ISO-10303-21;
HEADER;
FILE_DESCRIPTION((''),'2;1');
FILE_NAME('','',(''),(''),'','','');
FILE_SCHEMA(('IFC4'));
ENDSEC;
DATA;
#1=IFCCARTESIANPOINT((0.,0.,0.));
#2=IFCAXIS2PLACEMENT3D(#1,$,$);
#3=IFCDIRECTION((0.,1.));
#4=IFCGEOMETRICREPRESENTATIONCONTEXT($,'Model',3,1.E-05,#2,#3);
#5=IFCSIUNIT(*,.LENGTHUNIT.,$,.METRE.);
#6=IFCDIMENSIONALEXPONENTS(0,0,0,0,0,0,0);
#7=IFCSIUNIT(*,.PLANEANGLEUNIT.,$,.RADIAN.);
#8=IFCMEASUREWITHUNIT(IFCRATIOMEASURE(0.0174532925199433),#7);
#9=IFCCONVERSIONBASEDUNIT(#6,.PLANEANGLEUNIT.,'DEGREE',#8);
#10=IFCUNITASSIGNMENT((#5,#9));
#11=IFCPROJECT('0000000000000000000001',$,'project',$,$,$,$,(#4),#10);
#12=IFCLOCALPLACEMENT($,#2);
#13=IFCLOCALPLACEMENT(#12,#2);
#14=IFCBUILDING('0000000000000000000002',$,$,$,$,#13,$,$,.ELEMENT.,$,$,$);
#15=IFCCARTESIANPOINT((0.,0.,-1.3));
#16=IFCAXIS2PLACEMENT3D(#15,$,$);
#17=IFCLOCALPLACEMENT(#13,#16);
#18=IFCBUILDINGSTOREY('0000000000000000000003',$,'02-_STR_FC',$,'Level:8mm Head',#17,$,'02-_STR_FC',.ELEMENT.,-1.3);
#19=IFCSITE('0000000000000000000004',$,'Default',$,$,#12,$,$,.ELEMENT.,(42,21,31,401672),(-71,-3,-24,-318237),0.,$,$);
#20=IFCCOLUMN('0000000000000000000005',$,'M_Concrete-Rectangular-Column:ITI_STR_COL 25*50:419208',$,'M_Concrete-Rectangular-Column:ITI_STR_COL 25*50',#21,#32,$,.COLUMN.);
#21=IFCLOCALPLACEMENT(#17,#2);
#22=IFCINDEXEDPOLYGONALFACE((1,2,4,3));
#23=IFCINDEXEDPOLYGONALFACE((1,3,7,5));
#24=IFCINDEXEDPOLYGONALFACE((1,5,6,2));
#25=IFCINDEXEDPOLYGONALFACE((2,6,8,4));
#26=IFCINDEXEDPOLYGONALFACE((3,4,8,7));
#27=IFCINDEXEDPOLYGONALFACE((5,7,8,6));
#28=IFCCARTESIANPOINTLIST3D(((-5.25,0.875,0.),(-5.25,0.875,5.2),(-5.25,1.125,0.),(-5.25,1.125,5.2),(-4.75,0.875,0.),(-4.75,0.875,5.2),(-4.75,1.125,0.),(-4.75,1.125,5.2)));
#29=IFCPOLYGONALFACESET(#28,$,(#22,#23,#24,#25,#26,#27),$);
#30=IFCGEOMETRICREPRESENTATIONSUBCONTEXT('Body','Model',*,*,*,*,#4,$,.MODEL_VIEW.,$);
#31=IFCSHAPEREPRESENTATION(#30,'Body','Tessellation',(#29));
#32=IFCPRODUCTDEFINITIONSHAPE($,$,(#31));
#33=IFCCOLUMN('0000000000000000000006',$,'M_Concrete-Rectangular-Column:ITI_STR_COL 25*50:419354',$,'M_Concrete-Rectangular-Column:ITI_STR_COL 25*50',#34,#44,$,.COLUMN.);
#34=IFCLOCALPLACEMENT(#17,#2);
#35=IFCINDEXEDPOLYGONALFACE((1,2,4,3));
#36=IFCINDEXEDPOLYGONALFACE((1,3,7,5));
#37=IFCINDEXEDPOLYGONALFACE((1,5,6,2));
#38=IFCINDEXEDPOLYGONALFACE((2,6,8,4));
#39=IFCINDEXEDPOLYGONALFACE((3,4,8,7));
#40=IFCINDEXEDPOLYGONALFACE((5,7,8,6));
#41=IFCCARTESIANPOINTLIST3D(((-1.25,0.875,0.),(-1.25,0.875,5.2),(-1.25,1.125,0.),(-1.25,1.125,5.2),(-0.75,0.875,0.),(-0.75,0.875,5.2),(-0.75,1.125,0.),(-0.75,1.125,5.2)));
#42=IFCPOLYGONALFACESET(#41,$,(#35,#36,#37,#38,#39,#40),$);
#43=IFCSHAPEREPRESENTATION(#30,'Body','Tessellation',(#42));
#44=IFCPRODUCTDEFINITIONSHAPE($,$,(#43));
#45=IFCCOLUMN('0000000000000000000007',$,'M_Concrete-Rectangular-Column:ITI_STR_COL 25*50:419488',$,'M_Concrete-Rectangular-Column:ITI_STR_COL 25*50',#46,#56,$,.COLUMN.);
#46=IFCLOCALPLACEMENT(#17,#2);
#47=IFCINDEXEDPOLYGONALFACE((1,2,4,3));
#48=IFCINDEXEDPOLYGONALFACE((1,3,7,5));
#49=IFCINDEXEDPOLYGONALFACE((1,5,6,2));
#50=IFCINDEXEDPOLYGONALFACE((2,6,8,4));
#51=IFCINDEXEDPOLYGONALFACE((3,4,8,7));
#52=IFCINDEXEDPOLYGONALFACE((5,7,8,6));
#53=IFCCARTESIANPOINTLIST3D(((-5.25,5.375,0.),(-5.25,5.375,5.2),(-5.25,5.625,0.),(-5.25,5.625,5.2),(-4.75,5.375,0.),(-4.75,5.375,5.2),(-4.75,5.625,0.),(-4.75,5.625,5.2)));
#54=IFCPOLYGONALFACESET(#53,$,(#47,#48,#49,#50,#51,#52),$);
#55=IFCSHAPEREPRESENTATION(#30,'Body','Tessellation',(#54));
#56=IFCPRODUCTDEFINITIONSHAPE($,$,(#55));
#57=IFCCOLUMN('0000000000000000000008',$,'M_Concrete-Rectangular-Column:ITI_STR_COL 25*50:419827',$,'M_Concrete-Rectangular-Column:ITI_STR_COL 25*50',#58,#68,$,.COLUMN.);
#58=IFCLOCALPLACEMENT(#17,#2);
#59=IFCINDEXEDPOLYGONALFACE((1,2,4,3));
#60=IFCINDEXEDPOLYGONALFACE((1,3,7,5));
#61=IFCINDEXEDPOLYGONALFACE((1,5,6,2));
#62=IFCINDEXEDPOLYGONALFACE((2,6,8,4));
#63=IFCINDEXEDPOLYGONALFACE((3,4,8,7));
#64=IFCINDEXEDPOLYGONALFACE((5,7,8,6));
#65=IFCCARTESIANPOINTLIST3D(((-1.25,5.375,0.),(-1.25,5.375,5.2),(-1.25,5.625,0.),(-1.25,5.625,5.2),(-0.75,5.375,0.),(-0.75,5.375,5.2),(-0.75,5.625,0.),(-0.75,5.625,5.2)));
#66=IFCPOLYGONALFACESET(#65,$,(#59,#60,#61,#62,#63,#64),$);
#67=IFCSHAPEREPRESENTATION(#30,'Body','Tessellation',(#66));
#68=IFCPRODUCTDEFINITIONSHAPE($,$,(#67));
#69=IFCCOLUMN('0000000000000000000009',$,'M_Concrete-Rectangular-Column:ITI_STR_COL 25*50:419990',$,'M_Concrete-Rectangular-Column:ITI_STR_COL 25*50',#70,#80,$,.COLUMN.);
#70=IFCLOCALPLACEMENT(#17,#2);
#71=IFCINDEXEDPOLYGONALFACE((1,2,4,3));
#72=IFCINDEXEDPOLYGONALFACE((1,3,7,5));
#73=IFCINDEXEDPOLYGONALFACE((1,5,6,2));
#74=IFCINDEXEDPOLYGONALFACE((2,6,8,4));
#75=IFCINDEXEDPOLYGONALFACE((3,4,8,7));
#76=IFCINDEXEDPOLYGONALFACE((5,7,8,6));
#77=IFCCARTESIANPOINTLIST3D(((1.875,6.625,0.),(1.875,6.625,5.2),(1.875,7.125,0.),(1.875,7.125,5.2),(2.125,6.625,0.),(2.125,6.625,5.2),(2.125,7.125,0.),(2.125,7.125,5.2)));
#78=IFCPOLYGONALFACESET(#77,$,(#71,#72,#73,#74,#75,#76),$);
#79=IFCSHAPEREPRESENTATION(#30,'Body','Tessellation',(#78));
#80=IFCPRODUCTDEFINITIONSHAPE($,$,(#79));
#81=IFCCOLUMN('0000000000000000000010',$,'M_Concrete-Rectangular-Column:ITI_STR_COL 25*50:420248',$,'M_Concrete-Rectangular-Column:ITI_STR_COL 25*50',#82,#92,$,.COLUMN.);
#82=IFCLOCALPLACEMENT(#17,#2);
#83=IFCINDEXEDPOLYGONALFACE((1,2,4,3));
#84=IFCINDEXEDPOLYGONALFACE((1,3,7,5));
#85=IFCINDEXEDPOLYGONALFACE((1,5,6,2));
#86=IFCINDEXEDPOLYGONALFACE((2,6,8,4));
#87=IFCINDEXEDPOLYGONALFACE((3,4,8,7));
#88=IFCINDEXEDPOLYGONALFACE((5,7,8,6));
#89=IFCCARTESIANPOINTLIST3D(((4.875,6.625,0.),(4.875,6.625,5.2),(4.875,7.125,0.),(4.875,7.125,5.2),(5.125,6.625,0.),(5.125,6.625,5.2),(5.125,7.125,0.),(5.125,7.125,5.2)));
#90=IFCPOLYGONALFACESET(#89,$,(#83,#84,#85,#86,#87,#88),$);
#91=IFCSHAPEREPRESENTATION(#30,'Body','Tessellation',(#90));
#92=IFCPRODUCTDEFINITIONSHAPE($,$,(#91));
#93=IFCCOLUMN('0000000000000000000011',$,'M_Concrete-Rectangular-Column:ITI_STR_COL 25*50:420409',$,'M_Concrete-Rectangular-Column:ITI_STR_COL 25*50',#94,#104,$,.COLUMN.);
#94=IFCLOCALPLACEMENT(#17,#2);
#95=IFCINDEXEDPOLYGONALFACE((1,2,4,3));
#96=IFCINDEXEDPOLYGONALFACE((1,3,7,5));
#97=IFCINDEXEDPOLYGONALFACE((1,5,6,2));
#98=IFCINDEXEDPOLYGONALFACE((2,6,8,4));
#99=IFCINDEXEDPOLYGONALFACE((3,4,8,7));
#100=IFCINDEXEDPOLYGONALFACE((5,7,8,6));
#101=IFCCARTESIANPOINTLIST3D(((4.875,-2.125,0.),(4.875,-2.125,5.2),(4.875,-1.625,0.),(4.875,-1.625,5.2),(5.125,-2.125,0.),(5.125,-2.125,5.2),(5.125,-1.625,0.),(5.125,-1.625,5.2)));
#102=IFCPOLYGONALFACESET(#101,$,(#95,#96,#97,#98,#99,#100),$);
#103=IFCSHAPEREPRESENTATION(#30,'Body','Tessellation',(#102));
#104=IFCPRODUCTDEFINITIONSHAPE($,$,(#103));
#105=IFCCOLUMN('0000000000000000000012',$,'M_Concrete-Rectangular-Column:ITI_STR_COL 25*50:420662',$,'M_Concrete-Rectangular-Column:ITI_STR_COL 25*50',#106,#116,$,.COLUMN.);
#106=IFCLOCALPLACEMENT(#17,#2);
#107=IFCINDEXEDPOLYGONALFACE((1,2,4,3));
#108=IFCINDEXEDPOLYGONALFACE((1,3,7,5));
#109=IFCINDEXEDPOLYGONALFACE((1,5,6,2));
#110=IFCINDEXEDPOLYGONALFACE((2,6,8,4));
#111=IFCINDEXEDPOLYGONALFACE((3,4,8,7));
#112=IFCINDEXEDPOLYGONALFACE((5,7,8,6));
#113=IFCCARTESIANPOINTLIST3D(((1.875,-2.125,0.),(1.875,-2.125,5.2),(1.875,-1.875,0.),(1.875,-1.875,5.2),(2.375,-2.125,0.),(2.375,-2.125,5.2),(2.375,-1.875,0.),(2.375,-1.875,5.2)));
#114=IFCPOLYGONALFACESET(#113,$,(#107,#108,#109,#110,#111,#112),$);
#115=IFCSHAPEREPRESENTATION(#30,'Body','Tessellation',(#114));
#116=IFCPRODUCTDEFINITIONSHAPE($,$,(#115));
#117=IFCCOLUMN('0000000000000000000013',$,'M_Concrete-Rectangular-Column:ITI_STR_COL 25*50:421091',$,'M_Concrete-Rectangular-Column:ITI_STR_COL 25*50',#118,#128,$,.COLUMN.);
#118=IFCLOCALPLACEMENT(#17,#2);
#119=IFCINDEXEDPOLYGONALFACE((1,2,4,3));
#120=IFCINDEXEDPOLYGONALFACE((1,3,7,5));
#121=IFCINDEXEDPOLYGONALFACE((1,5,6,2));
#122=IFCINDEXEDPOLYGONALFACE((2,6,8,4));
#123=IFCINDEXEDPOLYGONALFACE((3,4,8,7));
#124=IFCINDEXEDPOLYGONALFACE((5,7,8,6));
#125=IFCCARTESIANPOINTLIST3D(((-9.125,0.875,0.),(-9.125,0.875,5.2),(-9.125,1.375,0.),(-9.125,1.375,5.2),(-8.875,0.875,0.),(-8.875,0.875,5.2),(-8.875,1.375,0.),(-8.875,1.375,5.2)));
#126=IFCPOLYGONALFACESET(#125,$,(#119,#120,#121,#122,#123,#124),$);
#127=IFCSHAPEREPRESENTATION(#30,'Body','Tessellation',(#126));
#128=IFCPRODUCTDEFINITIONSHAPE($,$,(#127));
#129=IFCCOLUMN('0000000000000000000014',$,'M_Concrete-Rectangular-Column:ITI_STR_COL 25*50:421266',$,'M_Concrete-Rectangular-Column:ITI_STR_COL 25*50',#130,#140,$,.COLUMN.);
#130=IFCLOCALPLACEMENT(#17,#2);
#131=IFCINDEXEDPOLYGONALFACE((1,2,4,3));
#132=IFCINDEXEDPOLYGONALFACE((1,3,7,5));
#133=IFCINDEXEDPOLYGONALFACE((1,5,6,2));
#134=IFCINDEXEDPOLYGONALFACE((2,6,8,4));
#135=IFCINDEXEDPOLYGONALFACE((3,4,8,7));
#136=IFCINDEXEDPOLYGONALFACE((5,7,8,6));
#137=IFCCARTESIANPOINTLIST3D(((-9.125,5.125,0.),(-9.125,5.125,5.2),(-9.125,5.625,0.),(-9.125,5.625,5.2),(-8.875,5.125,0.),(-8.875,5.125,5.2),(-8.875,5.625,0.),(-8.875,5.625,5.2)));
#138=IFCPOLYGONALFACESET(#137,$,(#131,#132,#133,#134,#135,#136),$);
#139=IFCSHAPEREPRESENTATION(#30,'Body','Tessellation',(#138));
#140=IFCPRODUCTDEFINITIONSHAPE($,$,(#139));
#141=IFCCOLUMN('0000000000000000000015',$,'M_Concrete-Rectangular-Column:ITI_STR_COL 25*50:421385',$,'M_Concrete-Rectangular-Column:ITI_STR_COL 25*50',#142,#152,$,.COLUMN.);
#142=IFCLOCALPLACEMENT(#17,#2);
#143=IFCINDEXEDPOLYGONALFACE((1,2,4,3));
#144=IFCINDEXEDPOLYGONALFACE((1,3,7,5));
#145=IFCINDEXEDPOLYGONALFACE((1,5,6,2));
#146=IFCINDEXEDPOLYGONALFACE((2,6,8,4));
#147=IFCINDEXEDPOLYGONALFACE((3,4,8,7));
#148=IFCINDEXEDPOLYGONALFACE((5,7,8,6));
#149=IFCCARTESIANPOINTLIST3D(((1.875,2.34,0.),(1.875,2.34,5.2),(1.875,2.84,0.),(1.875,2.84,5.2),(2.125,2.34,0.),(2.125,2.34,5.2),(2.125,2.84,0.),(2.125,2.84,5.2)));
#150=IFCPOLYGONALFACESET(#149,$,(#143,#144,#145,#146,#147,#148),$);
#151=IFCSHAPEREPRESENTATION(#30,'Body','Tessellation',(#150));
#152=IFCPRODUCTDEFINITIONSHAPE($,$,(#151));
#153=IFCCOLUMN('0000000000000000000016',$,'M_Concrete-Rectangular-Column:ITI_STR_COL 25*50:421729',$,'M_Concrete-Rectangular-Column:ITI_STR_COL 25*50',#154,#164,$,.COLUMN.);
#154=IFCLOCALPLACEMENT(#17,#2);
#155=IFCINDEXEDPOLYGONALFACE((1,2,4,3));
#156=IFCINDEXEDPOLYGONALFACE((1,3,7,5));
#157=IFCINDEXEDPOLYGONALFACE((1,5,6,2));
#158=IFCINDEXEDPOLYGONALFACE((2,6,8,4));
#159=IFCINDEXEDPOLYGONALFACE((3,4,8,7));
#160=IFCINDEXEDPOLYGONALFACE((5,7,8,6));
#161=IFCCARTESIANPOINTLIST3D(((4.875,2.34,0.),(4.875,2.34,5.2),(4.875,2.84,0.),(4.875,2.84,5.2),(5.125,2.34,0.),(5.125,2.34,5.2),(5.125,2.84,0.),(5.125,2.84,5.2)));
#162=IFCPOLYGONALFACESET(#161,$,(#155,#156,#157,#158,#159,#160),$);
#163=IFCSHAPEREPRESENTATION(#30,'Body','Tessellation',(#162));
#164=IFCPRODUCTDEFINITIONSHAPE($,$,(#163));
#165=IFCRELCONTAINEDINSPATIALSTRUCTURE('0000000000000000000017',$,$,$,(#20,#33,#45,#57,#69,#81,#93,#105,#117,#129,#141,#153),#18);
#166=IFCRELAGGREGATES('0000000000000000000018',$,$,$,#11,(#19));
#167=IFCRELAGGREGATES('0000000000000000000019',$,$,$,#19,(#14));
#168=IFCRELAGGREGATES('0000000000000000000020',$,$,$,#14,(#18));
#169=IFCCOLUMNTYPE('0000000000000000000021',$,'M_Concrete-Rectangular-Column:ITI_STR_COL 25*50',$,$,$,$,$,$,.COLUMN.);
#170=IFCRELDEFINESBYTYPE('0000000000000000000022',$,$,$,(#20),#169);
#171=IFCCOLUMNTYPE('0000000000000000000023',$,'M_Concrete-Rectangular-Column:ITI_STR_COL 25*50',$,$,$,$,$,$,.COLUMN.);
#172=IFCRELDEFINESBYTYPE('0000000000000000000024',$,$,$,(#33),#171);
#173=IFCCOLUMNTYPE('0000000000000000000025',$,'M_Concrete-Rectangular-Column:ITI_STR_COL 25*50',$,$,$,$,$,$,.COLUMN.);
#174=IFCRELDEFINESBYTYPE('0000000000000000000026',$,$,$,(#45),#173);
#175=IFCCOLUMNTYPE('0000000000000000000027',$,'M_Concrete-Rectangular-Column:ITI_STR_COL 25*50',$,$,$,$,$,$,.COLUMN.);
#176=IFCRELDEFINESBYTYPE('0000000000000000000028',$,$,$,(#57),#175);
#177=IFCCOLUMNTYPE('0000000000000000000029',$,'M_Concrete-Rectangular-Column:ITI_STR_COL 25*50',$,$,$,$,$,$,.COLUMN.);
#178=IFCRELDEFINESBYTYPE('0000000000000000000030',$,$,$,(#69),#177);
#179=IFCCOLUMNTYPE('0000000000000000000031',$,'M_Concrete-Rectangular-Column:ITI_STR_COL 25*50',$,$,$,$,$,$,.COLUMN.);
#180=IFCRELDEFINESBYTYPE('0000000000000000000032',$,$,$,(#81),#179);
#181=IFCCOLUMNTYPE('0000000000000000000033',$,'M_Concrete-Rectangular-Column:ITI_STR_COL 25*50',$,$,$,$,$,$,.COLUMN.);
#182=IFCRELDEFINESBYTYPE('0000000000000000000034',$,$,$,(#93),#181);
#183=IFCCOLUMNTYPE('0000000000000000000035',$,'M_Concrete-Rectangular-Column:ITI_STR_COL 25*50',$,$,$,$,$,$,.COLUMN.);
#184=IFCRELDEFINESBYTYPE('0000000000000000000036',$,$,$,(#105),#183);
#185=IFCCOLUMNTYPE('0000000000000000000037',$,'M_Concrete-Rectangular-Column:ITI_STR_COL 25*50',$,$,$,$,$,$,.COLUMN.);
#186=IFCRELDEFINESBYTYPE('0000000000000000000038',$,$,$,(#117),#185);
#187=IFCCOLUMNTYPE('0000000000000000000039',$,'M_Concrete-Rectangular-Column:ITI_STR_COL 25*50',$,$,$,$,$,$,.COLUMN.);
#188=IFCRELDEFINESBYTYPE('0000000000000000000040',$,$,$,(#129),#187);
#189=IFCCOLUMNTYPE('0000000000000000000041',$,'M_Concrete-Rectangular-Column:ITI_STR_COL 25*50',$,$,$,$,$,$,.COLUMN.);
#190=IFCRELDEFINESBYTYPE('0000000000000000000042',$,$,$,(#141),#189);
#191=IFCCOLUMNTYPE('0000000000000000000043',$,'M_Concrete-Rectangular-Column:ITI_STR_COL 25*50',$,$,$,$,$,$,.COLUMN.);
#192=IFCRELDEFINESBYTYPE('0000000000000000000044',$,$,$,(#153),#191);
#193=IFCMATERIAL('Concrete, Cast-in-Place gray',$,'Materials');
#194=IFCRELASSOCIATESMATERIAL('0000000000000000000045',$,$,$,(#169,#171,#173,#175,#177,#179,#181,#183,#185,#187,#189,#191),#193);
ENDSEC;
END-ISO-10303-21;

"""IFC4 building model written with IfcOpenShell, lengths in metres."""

from ifc_helpers import new_model, entity, si_unit, converted_unit, direction, frame, origin, place, context, subcontext, project, spatial, indexed_curve, outline, extrude, source, transform, mapped, material, type_object, type_shapes, element, save


model = new_model("IFC4")

# Units and contexts
model_context = context("Model", 3, precision=1e-05, world=origin(), true_north=direction((0.0, 1.0)))
body_context = subcontext(model_context, "Body", "Model", "MODEL_VIEW")
ifc_project = project(units=[si_unit("LENGTHUNIT", "METRE"), converted_unit("PLANEANGLEUNIT", "DEGREE", entity("IfcRatioMeasure", 0.0174532925199433), si_unit("PLANEANGLEUNIT", "RADIAN"), dimensions=[0, 0, 0, 0, 0, 0, 0])], contexts=[model_context])

# Site, building, storey
site_placement = place(None, origin())
site = spatial("IfcSite", under=ifc_project, at=site_placement, Name="Default", CompositionType="ELEMENT", RefLatitude=(42, 21, 31, 401672), RefLongitude=(-71, -3, -24, -318237), RefElevation=0.0)
building_placement = place(site_placement, origin())
building = spatial("IfcBuilding", under=site, at=building_placement, CompositionType="ELEMENT")
storey_placement = place(building_placement, frame((0.0, 0.0, -1.3)))
storey = spatial("IfcBuildingStorey", under=building, at=storey_placement, Name="02-_STR_FC", ObjectType="Level:8mm Head", LongName="02-_STR_FC", CompositionType="ELEMENT", Elevation=-1.3)

# Columns
ifc_material = material(Name="Concrete, Cast-in-Place gray", Category="Materials")
column_type_1 = type_object("IfcColumnType", Name="M_Concrete-Rectangular-Column:ITI_STR_COL 25*50", PredefinedType="COLUMN", material=ifc_material)
shared_shape_1 = source(origin(), body_context, "Body", "SweptSolid", [
    extrude(outline(indexed_curve([(-0.125, -0.25), (0.125, -0.25), (0.125, 0.25), (-0.125, 0.25), (-0.125, -0.25)], self_intersect=False)), frame((-5.0, 1.0, -1.3), z_axis=(0.0, 0.0, 1.0), x_axis=(0.0, -1.0, 0.0)), (0.0, 0.0, 1.0), 5.2),
])
type_shapes(column_type_1, [shared_shape_1])
column_1_placement = place(storey_placement, frame((0.0, 0.0, 1.3)))
element("IfcColumn", 1, at=column_1_placement, inside=storey, type_object=column_type_1, Name="M_Concrete-Rectangular-Column:ITI_STR_COL 25*50:419208", ObjectType="M_Concrete-Rectangular-Column:ITI_STR_COL 25*50", PredefinedType="COLUMN", context=body_context, shape_type="MappedRepresentation", body=[
    mapped(shared_shape_1, transform((0.0, 0.0, 0.0), scale=1.0)),
])
column_type_2 = type_object("IfcColumnType", Name="M_Concrete-Rectangular-Column:ITI_STR_COL 25*50", PredefinedType="COLUMN", material=ifc_material)
shared_shape_2 = source(origin(), body_context, "Body", "SweptSolid", [
    extrude(outline(indexed_curve([(-0.125, -0.25), (0.125, -0.25), (0.125, 0.25), (-0.125, 0.25), (-0.125, -0.25)], self_intersect=False)), frame((-1.0, 1.0, -1.3), z_axis=(0.0, 0.0, 1.0), x_axis=(0.0, -1.0, 0.0)), (0.0, 0.0, 1.0), 5.2),
])
type_shapes(column_type_2, [shared_shape_2])
column_2_placement = place(storey_placement, frame((0.0, 0.0, 1.3)))
element("IfcColumn", 2, at=column_2_placement, inside=storey, type_object=column_type_2, Name="M_Concrete-Rectangular-Column:ITI_STR_COL 25*50:419354", ObjectType="M_Concrete-Rectangular-Column:ITI_STR_COL 25*50", PredefinedType="COLUMN", context=body_context, shape_type="MappedRepresentation", body=[
    mapped(shared_shape_2, transform((0.0, 0.0, 0.0), scale=1.0)),
])
column_type_3 = type_object("IfcColumnType", Name="M_Concrete-Rectangular-Column:ITI_STR_COL 25*50", PredefinedType="COLUMN", material=ifc_material)
shared_shape_3 = source(origin(), body_context, "Body", "SweptSolid", [
    extrude(outline(indexed_curve([(-0.125, -0.25), (0.125, -0.25), (0.125, 0.25), (-0.125, 0.25), (-0.125, -0.25)], self_intersect=False)), frame((-5.0, 5.5, -1.3), z_axis=(0.0, 0.0, 1.0), x_axis=(0.0, -1.0, 0.0)), (0.0, 0.0, 1.0), 5.2),
])
type_shapes(column_type_3, [shared_shape_3])
column_3_placement = place(storey_placement, frame((0.0, 0.0, 1.3)))
element("IfcColumn", 3, at=column_3_placement, inside=storey, type_object=column_type_3, Name="M_Concrete-Rectangular-Column:ITI_STR_COL 25*50:419488", ObjectType="M_Concrete-Rectangular-Column:ITI_STR_COL 25*50", PredefinedType="COLUMN", context=body_context, shape_type="MappedRepresentation", body=[
    mapped(shared_shape_3, transform((0.0, 0.0, 0.0), scale=1.0)),
])
column_type_4 = type_object("IfcColumnType", Name="M_Concrete-Rectangular-Column:ITI_STR_COL 25*50", PredefinedType="COLUMN", material=ifc_material)
shared_shape_4 = source(origin(), body_context, "Body", "SweptSolid", [
    extrude(outline(indexed_curve([(-0.125, -0.25), (0.125, -0.25), (0.125, 0.25), (-0.125, 0.25), (-0.125, -0.25)], self_intersect=False)), frame((-1.0, 5.5, -1.3), z_axis=(0.0, 0.0, 1.0), x_axis=(0.0, -1.0, 0.0)), (0.0, 0.0, 1.0), 5.2),
])
type_shapes(column_type_4, [shared_shape_4])
column_4_placement = place(storey_placement, frame((0.0, 0.0, 1.3)))
element("IfcColumn", 4, at=column_4_placement, inside=storey, type_object=column_type_4, Name="M_Concrete-Rectangular-Column:ITI_STR_COL 25*50:419827", ObjectType="M_Concrete-Rectangular-Column:ITI_STR_COL 25*50", PredefinedType="COLUMN", context=body_context, shape_type="MappedRepresentation", body=[
    mapped(shared_shape_4, transform((0.0, 0.0, 0.0), scale=1.0)),
])
column_type_5 = type_object("IfcColumnType", Name="M_Concrete-Rectangular-Column:ITI_STR_COL 25*50", PredefinedType="COLUMN", material=ifc_material)
shared_shape_5 = source(origin(), body_context, "Body", "SweptSolid", [
    extrude(outline(indexed_curve([(-0.25, -0.125), (0.25, -0.125), (0.25, 0.125), (-0.25, 0.125), (-0.25, -0.125)], self_intersect=False)), frame((2.0, 6.875, -1.3), z_axis=(0.0, 0.0, 1.0), x_axis=(0.0, -1.0, 0.0)), (0.0, 0.0, 1.0), 5.2),
])
type_shapes(column_type_5, [shared_shape_5])
column_5_placement = place(storey_placement, frame((0.0, 0.0, 1.3)))
element("IfcColumn", 5, at=column_5_placement, inside=storey, type_object=column_type_5, Name="M_Concrete-Rectangular-Column:ITI_STR_COL 25*50:419990", ObjectType="M_Concrete-Rectangular-Column:ITI_STR_COL 25*50", PredefinedType="COLUMN", context=body_context, shape_type="MappedRepresentation", body=[
    mapped(shared_shape_5, transform((0.0, 0.0, 0.0), scale=1.0)),
])
column_type_6 = type_object("IfcColumnType", Name="M_Concrete-Rectangular-Column:ITI_STR_COL 25*50", PredefinedType="COLUMN", material=ifc_material)
shared_shape_6 = source(origin(), body_context, "Body", "SweptSolid", [
    extrude(outline(indexed_curve([(-0.25, -0.125), (0.25, -0.125), (0.25, 0.125), (-0.25, 0.125), (-0.25, -0.125)], self_intersect=False)), frame((5.0, 6.875, -1.3), z_axis=(0.0, 0.0, 1.0), x_axis=(0.0, -1.0, 0.0)), (0.0, 0.0, 1.0), 5.2),
])
type_shapes(column_type_6, [shared_shape_6])
column_6_placement = place(storey_placement, frame((0.0, 0.0, 1.3)))
element("IfcColumn", 6, at=column_6_placement, inside=storey, type_object=column_type_6, Name="M_Concrete-Rectangular-Column:ITI_STR_COL 25*50:420248", ObjectType="M_Concrete-Rectangular-Column:ITI_STR_COL 25*50", PredefinedType="COLUMN", context=body_context, shape_type="MappedRepresentation", body=[
    mapped(shared_shape_6, transform((0.0, 0.0, 0.0), scale=1.0)),
])
column_type_7 = type_object("IfcColumnType", Name="M_Concrete-Rectangular-Column:ITI_STR_COL 25*50", PredefinedType="COLUMN", material=ifc_material)
shared_shape_7 = source(origin(), body_context, "Body", "SweptSolid", [
    extrude(outline(indexed_curve([(-0.25, -0.125), (0.25, -0.125), (0.25, 0.125), (-0.25, 0.125), (-0.25, -0.125)], self_intersect=False)), frame((5.0, -1.875, -1.3), z_axis=(0.0, 0.0, 1.0), x_axis=(0.0, -1.0, 0.0)), (0.0, 0.0, 1.0), 5.2),
])
type_shapes(column_type_7, [shared_shape_7])
column_7_placement = place(storey_placement, frame((0.0, 0.0, 1.3)))
element("IfcColumn", 7, at=column_7_placement, inside=storey, type_object=column_type_7, Name="M_Concrete-Rectangular-Column:ITI_STR_COL 25*50:420409", ObjectType="M_Concrete-Rectangular-Column:ITI_STR_COL 25*50", PredefinedType="COLUMN", context=body_context, shape_type="MappedRepresentation", body=[
    mapped(shared_shape_7, transform((0.0, 0.0, 0.0), scale=1.0)),
])
column_type_8 = type_object("IfcColumnType", Name="M_Concrete-Rectangular-Column:ITI_STR_COL 25*50", PredefinedType="COLUMN", material=ifc_material)
shared_shape_8 = source(origin(), body_context, "Body", "SweptSolid", [
    extrude(outline(indexed_curve([(-0.125, -0.25), (0.125, -0.25), (0.125, 0.25), (-0.125, 0.25), (-0.125, -0.25)], self_intersect=False)), frame((2.125, -2.0, -1.3), z_axis=(0.0, 0.0, 1.0), x_axis=(0.0, -1.0, 0.0)), (0.0, 0.0, 1.0), 5.2),
])
type_shapes(column_type_8, [shared_shape_8])
column_8_placement = place(storey_placement, frame((0.0, 0.0, 1.3)))
element("IfcColumn", 8, at=column_8_placement, inside=storey, type_object=column_type_8, Name="M_Concrete-Rectangular-Column:ITI_STR_COL 25*50:420662", ObjectType="M_Concrete-Rectangular-Column:ITI_STR_COL 25*50", PredefinedType="COLUMN", context=body_context, shape_type="MappedRepresentation", body=[
    mapped(shared_shape_8, transform((0.0, 0.0, 0.0), scale=1.0)),
])
column_type_9 = type_object("IfcColumnType", Name="M_Concrete-Rectangular-Column:ITI_STR_COL 25*50", PredefinedType="COLUMN", material=ifc_material)
shared_shape_9 = source(origin(), body_context, "Body", "SweptSolid", [
    extrude(outline(indexed_curve([(-0.25, -0.125), (0.25, -0.125), (0.25, 0.125), (-0.25, 0.125), (-0.25, -0.125)], self_intersect=False)), frame((-9.0, 1.125, -1.3), z_axis=(0.0, 0.0, 1.0), x_axis=(0.0, -1.0, 0.0)), (0.0, 0.0, 1.0), 5.2),
])
type_shapes(column_type_9, [shared_shape_9])
column_9_placement = place(storey_placement, frame((0.0, 0.0, 1.3)))
element("IfcColumn", 9, at=column_9_placement, inside=storey, type_object=column_type_9, Name="M_Concrete-Rectangular-Column:ITI_STR_COL 25*50:421091", ObjectType="M_Concrete-Rectangular-Column:ITI_STR_COL 25*50", PredefinedType="COLUMN", context=body_context, shape_type="MappedRepresentation", body=[
    mapped(shared_shape_9, transform((0.0, 0.0, 0.0), scale=1.0)),
])
column_type_10 = type_object("IfcColumnType", Name="M_Concrete-Rectangular-Column:ITI_STR_COL 25*50", PredefinedType="COLUMN", material=ifc_material)
shared_shape_10 = source(origin(), body_context, "Body", "SweptSolid", [
    extrude(outline(indexed_curve([(-0.25, -0.125), (0.25, -0.125), (0.25, 0.125), (-0.25, 0.125), (-0.25, -0.125)], self_intersect=False)), frame((-9.0, 5.375, -1.3), z_axis=(0.0, 0.0, 1.0), x_axis=(0.0, -1.0, 0.0)), (0.0, 0.0, 1.0), 5.2),
])
type_shapes(column_type_10, [shared_shape_10])
column_10_placement = place(storey_placement, frame((0.0, 0.0, 1.3)))
element("IfcColumn", 10, at=column_10_placement, inside=storey, type_object=column_type_10, Name="M_Concrete-Rectangular-Column:ITI_STR_COL 25*50:421266", ObjectType="M_Concrete-Rectangular-Column:ITI_STR_COL 25*50", PredefinedType="COLUMN", context=body_context, shape_type="MappedRepresentation", body=[
    mapped(shared_shape_10, transform((0.0, 0.0, 0.0), scale=1.0)),
])
column_type_11 = type_object("IfcColumnType", Name="M_Concrete-Rectangular-Column:ITI_STR_COL 25*50", PredefinedType="COLUMN", material=ifc_material)
shared_shape_11 = source(origin(), body_context, "Body", "SweptSolid", [
    extrude(outline(indexed_curve([(-0.25, -0.125), (0.25, -0.125), (0.25, 0.125), (-0.25, 0.125), (-0.25, -0.125)], self_intersect=False)), frame((2.0, 2.59, -1.3), z_axis=(0.0, 0.0, 1.0), x_axis=(0.0, -1.0, 0.0)), (0.0, 0.0, 1.0), 5.2),
])
type_shapes(column_type_11, [shared_shape_11])
column_11_placement = place(storey_placement, frame((0.0, 0.0, 1.3)))
element("IfcColumn", 11, at=column_11_placement, inside=storey, type_object=column_type_11, Name="M_Concrete-Rectangular-Column:ITI_STR_COL 25*50:421385", ObjectType="M_Concrete-Rectangular-Column:ITI_STR_COL 25*50", PredefinedType="COLUMN", context=body_context, shape_type="MappedRepresentation", body=[
    mapped(shared_shape_11, transform((0.0, 0.0, 0.0), scale=1.0)),
])
column_type_12 = type_object("IfcColumnType", Name="M_Concrete-Rectangular-Column:ITI_STR_COL 25*50", PredefinedType="COLUMN", material=ifc_material)
shared_shape_12 = source(origin(), body_context, "Body", "SweptSolid", [
    extrude(outline(indexed_curve([(-0.25, -0.125), (0.25, -0.125), (0.25, 0.125), (-0.25, 0.125), (-0.25, -0.125)], self_intersect=False)), frame((5.0, 2.59, -1.3), z_axis=(0.0, 0.0, 1.0), x_axis=(0.0, -1.0, 0.0)), (0.0, 0.0, 1.0), 5.2),
])
type_shapes(column_type_12, [shared_shape_12])
column_12_placement = place(storey_placement, frame((0.0, 0.0, 1.3)))
element("IfcColumn", 12, at=column_12_placement, inside=storey, type_object=column_type_12, Name="M_Concrete-Rectangular-Column:ITI_STR_COL 25*50:421729", ObjectType="M_Concrete-Rectangular-Column:ITI_STR_COL 25*50", PredefinedType="COLUMN", context=body_context, shape_type="MappedRepresentation", body=[
    mapped(shared_shape_12, transform((0.0, 0.0, 0.0), scale=1.0)),
])

save(model, "model.ifc")
